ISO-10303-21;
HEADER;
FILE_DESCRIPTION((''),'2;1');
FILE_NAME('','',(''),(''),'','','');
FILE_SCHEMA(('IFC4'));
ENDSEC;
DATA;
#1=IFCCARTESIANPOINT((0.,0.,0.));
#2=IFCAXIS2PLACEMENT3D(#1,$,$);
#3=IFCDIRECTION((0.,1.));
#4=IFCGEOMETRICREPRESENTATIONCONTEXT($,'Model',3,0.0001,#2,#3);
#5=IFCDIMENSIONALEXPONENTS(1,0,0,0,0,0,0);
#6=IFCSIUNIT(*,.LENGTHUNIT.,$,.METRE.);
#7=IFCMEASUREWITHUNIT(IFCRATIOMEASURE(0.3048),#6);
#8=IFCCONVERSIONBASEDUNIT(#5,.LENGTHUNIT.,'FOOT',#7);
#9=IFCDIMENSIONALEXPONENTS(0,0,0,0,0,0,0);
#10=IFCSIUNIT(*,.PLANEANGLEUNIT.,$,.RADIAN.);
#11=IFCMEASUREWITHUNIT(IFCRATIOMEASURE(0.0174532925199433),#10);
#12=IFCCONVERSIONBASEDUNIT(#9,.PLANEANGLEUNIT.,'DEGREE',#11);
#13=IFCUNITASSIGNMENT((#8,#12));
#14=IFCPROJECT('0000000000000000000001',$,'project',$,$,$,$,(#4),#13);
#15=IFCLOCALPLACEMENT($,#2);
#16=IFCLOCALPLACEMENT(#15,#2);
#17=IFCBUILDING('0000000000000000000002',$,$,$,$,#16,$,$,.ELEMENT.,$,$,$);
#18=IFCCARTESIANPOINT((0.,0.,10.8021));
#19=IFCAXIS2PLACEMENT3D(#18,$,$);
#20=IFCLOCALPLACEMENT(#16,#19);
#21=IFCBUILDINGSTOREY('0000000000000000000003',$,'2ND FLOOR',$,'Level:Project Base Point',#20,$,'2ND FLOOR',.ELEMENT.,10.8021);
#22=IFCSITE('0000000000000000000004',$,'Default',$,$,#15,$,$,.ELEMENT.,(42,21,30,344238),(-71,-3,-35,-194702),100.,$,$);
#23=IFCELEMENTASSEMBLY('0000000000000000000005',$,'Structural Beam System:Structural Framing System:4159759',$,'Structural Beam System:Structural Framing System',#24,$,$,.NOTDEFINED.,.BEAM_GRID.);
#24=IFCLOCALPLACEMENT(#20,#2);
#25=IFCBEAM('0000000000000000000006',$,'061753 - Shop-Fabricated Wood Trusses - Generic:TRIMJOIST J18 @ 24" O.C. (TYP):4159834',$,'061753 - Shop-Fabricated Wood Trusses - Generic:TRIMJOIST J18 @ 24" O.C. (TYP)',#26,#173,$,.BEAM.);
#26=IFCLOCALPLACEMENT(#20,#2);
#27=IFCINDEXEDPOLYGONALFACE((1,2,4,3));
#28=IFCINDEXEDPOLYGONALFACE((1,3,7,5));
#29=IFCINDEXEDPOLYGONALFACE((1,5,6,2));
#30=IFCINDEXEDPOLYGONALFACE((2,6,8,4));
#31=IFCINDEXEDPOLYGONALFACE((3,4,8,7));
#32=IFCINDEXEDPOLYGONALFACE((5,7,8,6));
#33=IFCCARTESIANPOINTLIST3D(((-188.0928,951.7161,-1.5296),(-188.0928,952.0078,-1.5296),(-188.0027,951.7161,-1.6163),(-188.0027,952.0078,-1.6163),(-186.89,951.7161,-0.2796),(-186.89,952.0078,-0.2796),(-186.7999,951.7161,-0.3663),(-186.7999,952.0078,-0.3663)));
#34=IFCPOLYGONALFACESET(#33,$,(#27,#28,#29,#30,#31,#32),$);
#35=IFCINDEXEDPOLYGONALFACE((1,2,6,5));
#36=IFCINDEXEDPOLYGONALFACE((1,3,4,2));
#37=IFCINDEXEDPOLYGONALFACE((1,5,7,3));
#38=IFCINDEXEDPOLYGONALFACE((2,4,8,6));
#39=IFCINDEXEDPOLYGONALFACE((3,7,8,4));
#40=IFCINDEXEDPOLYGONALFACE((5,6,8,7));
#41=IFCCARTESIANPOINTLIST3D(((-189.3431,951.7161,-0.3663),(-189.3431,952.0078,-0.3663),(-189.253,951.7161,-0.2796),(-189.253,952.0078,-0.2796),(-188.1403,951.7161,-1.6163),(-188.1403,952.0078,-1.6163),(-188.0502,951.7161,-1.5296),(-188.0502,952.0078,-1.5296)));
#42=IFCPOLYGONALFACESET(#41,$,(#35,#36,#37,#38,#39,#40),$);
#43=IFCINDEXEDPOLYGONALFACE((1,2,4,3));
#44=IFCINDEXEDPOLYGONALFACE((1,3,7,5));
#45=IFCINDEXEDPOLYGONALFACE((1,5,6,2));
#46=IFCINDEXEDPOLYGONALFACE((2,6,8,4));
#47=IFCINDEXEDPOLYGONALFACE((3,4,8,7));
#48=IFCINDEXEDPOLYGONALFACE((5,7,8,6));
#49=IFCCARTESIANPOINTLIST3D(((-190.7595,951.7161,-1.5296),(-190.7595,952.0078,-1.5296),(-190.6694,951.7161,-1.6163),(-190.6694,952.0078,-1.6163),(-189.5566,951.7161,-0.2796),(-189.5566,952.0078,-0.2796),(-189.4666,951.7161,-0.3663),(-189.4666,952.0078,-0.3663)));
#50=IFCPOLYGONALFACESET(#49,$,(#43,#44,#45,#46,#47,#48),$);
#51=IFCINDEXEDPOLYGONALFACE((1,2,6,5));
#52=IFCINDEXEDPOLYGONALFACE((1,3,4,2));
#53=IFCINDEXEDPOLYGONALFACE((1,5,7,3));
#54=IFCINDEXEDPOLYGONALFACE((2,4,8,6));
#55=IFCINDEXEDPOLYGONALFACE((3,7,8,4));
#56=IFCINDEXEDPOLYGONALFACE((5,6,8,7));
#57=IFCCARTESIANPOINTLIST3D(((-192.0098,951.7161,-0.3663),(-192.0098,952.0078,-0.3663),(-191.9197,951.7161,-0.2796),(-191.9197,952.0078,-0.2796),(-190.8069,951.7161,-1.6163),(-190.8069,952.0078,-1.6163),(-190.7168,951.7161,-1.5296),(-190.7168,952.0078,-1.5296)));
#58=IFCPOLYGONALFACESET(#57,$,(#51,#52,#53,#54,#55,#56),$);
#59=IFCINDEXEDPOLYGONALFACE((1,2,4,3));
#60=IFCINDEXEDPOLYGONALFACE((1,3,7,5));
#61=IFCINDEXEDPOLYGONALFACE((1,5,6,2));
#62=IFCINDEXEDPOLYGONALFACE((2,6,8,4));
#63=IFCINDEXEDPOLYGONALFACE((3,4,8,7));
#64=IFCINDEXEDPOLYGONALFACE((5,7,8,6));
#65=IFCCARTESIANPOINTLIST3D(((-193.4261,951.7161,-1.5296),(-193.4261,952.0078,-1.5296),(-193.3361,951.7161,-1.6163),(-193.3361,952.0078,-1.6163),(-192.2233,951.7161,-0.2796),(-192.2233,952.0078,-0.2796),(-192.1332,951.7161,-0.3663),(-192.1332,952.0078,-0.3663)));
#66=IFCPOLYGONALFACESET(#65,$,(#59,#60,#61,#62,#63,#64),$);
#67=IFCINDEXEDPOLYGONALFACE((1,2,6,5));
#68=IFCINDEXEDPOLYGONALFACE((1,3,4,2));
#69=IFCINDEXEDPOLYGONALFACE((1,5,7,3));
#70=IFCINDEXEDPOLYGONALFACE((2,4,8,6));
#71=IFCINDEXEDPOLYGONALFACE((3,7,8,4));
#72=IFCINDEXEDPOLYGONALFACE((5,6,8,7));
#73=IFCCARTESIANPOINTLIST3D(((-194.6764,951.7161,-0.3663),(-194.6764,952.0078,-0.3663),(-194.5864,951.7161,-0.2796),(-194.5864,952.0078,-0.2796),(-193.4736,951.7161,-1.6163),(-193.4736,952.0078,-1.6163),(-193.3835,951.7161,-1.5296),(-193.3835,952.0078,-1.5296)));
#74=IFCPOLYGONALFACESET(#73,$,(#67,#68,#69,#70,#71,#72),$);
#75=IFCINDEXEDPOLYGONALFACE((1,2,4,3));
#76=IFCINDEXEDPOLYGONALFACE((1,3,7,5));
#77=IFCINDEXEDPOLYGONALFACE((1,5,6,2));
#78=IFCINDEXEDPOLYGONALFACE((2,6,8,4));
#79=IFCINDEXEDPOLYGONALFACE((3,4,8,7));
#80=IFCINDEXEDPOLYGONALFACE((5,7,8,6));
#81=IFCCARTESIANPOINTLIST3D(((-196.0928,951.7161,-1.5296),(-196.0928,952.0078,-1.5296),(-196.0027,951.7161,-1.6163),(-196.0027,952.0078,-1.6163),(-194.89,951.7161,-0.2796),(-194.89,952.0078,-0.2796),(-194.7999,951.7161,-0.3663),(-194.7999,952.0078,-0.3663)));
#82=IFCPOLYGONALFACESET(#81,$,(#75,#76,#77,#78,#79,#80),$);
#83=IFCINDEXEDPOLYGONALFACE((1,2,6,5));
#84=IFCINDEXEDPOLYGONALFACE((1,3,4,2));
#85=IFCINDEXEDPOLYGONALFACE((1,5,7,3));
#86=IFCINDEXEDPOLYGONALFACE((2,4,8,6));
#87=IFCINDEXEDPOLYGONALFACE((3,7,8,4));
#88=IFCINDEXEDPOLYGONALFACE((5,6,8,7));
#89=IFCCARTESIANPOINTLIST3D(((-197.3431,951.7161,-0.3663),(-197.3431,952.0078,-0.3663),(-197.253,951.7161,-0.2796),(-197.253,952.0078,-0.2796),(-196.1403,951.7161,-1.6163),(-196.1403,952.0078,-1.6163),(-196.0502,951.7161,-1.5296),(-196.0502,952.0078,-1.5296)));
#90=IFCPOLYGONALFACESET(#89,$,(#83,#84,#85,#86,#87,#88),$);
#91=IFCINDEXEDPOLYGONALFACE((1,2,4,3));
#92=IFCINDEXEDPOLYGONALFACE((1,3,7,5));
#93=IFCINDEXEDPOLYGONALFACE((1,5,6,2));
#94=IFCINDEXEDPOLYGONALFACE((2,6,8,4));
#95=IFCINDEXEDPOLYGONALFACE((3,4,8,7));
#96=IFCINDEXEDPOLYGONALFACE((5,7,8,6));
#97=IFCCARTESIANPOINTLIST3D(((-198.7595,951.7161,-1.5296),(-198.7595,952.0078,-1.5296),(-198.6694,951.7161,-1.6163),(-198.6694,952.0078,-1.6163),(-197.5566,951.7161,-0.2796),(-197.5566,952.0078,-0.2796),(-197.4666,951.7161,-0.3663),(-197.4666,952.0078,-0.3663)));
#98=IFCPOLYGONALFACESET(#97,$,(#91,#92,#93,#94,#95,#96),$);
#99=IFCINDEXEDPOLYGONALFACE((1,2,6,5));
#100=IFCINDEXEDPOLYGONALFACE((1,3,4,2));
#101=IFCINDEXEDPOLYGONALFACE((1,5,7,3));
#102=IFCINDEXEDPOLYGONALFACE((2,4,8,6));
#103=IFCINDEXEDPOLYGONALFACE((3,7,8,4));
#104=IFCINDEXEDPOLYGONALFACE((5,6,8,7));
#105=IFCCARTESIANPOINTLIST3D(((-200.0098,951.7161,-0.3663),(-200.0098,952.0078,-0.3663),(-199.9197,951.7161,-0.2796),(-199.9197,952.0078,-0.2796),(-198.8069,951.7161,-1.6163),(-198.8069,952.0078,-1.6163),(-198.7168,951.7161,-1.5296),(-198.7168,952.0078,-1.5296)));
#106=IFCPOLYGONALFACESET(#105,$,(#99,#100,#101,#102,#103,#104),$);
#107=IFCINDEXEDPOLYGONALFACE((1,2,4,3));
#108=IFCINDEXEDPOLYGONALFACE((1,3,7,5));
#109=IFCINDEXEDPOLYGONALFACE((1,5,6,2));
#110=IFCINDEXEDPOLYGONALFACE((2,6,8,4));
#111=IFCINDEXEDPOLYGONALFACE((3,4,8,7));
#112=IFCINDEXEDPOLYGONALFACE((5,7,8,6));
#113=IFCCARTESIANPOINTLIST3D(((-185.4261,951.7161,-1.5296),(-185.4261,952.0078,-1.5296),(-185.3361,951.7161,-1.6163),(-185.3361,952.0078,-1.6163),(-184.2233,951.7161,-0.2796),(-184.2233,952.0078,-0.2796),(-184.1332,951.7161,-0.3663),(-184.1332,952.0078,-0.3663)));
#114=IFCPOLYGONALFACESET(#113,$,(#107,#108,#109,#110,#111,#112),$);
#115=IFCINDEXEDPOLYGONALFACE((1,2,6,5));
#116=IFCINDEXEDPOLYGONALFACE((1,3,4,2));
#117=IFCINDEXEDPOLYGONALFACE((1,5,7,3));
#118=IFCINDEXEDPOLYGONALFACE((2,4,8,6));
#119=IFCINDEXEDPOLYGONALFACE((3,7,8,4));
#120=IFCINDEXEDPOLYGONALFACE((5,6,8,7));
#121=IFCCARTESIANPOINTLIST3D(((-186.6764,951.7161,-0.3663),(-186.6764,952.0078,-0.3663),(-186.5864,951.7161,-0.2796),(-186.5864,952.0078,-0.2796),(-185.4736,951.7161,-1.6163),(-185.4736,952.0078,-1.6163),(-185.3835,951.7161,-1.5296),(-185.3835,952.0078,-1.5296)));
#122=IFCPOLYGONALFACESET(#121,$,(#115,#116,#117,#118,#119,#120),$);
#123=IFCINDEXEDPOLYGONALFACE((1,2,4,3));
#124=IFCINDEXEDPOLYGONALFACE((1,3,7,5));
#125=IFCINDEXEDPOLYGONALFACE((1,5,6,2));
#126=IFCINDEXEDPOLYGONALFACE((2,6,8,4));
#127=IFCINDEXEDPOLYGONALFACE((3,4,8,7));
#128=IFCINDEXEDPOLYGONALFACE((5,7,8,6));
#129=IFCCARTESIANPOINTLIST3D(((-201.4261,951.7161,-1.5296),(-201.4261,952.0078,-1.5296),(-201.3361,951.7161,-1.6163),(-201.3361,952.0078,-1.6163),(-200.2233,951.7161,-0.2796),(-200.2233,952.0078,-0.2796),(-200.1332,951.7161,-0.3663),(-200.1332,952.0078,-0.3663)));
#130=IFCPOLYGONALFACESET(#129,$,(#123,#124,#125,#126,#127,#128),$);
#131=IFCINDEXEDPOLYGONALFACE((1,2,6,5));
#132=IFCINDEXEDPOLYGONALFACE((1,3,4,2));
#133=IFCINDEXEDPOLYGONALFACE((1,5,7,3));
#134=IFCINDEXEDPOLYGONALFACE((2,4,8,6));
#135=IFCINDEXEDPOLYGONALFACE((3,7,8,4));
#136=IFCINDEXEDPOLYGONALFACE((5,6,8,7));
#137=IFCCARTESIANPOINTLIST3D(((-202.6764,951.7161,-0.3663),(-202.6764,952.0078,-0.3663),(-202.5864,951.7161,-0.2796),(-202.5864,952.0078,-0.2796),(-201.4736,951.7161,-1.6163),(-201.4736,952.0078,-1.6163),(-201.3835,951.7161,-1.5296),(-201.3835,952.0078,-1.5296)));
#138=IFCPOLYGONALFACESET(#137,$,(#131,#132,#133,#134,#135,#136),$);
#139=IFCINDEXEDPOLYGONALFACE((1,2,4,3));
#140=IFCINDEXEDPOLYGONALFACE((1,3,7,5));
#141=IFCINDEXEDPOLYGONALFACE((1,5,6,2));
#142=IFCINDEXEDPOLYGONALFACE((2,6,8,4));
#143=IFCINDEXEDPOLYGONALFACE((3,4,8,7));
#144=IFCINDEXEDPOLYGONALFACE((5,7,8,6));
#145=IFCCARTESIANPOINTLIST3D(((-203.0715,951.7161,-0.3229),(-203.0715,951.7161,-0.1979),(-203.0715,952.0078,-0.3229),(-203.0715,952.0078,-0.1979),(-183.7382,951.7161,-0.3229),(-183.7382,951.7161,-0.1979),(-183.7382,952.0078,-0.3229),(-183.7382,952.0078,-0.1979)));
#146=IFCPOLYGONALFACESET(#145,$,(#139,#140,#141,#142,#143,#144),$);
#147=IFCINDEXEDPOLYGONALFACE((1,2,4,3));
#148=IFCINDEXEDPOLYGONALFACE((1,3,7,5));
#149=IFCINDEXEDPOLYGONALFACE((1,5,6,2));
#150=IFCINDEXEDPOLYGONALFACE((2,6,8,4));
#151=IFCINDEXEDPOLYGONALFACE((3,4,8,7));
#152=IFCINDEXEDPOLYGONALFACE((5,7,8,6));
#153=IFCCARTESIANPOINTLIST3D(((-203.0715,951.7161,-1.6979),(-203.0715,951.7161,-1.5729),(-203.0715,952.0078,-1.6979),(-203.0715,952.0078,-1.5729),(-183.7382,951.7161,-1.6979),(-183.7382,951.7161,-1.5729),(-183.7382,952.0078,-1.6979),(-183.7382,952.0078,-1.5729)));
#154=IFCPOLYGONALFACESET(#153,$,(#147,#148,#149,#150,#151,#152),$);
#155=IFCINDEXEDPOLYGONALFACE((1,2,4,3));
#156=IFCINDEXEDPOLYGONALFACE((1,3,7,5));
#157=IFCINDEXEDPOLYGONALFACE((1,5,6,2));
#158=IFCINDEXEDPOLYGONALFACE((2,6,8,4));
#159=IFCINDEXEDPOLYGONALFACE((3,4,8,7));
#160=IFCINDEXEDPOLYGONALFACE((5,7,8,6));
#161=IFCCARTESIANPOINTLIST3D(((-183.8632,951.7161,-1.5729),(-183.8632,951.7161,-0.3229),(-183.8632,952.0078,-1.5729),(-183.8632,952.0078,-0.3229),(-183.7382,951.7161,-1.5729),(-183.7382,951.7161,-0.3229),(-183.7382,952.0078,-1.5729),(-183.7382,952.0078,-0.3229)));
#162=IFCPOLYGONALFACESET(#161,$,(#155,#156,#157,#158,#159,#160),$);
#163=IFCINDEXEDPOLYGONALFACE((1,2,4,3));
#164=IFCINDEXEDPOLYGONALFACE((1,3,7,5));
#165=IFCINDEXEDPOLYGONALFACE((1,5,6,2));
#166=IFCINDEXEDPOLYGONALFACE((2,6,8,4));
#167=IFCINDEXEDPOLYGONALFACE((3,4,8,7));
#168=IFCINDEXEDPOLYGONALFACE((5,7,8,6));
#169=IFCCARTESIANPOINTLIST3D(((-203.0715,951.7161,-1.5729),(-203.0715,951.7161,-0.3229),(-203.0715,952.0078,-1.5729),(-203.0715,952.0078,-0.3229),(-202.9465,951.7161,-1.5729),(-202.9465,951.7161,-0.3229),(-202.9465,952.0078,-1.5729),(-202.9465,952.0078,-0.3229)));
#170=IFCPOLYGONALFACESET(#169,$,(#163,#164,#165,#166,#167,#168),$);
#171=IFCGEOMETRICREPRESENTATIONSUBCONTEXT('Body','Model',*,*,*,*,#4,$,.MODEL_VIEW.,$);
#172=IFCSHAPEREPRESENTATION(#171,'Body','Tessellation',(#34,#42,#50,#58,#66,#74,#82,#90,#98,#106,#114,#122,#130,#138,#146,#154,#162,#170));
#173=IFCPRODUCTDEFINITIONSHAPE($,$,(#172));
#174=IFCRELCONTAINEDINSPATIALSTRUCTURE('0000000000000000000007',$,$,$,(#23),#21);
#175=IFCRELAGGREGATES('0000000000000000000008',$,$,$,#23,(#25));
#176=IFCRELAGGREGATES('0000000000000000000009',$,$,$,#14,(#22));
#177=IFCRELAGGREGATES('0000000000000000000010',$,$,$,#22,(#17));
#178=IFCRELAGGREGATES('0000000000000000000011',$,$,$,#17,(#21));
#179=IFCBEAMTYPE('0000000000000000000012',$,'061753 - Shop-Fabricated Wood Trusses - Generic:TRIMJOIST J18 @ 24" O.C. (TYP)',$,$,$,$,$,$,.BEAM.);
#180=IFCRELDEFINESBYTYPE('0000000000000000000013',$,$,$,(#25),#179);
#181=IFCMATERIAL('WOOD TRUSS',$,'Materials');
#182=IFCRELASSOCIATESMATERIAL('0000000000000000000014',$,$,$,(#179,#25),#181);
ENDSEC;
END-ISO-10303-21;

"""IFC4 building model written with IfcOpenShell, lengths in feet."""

from ifc_helpers import new_model, entity, si_unit, converted_unit, direction, frame, frame_2d, origin, origin_2d_with_axis, place, context, subcontext, project, spatial, rectangle, extrude, source, transform, mapped, material, material_profile, profile_set, profile_usage, type_object, type_shapes, element, aggregate, save


model = new_model("IFC4")

# Units and contexts
model_context = context("Model", 3, precision=0.0001, world=origin(), true_north=direction((0.0, 1.0)))
body_context = subcontext(model_context, "Body", "Model", "MODEL_VIEW")
ifc_project = project(units=[converted_unit("LENGTHUNIT", "FOOT", entity("IfcRatioMeasure", 0.3048), si_unit("LENGTHUNIT", "METRE"), dimensions=[1, 0, 0, 0, 0, 0, 0]), converted_unit("PLANEANGLEUNIT", "DEGREE", entity("IfcRatioMeasure", 0.0174532925199433), si_unit("PLANEANGLEUNIT", "RADIAN"), dimensions=[0, 0, 0, 0, 0, 0, 0])], contexts=[model_context])

# Site, building, storey
site_placement = place(None, origin())
site = spatial("IfcSite", under=ifc_project, at=site_placement, Name="Default", CompositionType="ELEMENT", RefLatitude=(42, 21, 30, 344238), RefLongitude=(-71, -3, -35, -194702), RefElevation=100.0)
building_placement = place(site_placement, origin())
building = spatial("IfcBuilding", under=site, at=building_placement, CompositionType="ELEMENT")
storey_placement = place(building_placement, frame((0.0, 0.0, 10.8021)))
storey = spatial("IfcBuildingStorey", under=building, at=storey_placement, Name="2ND FLOOR", ObjectType="Level:Project Base Point", LongName="2ND FLOOR", CompositionType="ELEMENT", Elevation=10.8021)

# Element assembly, beam
ifc_material_1 = material(Name="WOOD TRUSS", Category="Materials")
ifc_material_profile_1 = material_profile(ifc_material_1, rectangle(XDim=1.7347, YDim=0.125, at=frame_2d((0.0, 0.0), x_axis=(1.0, 0.0))), Name="TRIMJOIST J18 @ 24\" O.C. (TYP)")
ifc_material_profile_2 = material_profile(ifc_material_1, rectangle(XDim=1.7347, YDim=0.125, at=frame_2d((0.0, 0.0), x_axis=(1.0, 0.0))), Name="TRIMJOIST J18 @ 24\" O.C. (TYP)")
ifc_material_profile_3 = material_profile(ifc_material_1, rectangle(XDim=1.7347, YDim=0.125, at=frame_2d((0.0, 0.0), x_axis=(1.0, 0.0))), Name="TRIMJOIST J18 @ 24\" O.C. (TYP)")
ifc_material_profile_4 = material_profile(ifc_material_1, rectangle(XDim=1.7347, YDim=0.125, at=frame_2d((0.0, 0.0), x_axis=(1.0, 0.0))), Name="TRIMJOIST J18 @ 24\" O.C. (TYP)")
ifc_material_profile_5 = material_profile(ifc_material_1, rectangle(XDim=1.7347, YDim=0.125, at=frame_2d((0.0, 0.0), x_axis=(1.0, 0.0))), Name="TRIMJOIST J18 @ 24\" O.C. (TYP)")
ifc_material_profile_6 = material_profile(ifc_material_1, rectangle(XDim=1.7347, YDim=0.125, at=frame_2d((0.0, 0.0), x_axis=(1.0, 0.0))), Name="TRIMJOIST J18 @ 24\" O.C. (TYP)")
ifc_material_profile_7 = material_profile(ifc_material_1, rectangle(XDim=1.7347, YDim=0.125, at=frame_2d((0.0, 0.0), x_axis=(1.0, 0.0))), Name="TRIMJOIST J18 @ 24\" O.C. (TYP)")
ifc_material_profile_8 = material_profile(ifc_material_1, rectangle(XDim=1.7347, YDim=0.125, at=frame_2d((0.0, 0.0), x_axis=(1.0, 0.0))), Name="TRIMJOIST J18 @ 24\" O.C. (TYP)")
ifc_material_profile_9 = material_profile(ifc_material_1, rectangle(XDim=1.7347, YDim=0.125, at=frame_2d((0.0, 0.0), x_axis=(1.0, 0.0))), Name="TRIMJOIST J18 @ 24\" O.C. (TYP)")
ifc_material_profile_10 = material_profile(ifc_material_1, rectangle(XDim=1.7347, YDim=0.125, at=origin_2d_with_axis()), Name="TRIMJOIST J18 @ 24\" O.C. (TYP)")
ifc_material_profile_11 = material_profile(ifc_material_1, rectangle(XDim=0.125, YDim=0.2917, at=origin_2d_with_axis()), Name="TRIMJOIST J18 @ 24\" O.C. (TYP)")
ifc_material_profile_12 = material_profile(ifc_material_1, rectangle(XDim=0.125, YDim=0.2917, at=origin_2d_with_axis()), Name="TRIMJOIST J18 @ 24\" O.C. (TYP)")
ifc_material_profile_13 = material_profile(ifc_material_1, rectangle(XDim=1.25, YDim=0.2917, at=origin_2d_with_axis()), Name="TRIMJOIST J18 @ 24\" O.C. (TYP)")
ifc_material_profile_14 = material_profile(ifc_material_1, rectangle(XDim=1.25, YDim=0.2917, at=origin_2d_with_axis()), Name="TRIMJOIST J18 @ 24\" O.C. (TYP)")
ifc_profile_set_1 = profile_set([ifc_material_profile_1, ifc_material_profile_2, ifc_material_profile_3, ifc_material_profile_4, ifc_material_profile_5, ifc_material_profile_6, ifc_material_profile_7, ifc_material_profile_8, ifc_material_profile_9, ifc_material_profile_10, ifc_material_profile_11, ifc_material_profile_12, ifc_material_profile_13, ifc_material_profile_14], Name="TRIMJOIST J18 @ 24\" O.C. (TYP)")
beam_type_1 = type_object("IfcBeamType", Name="061753 - Shop-Fabricated Wood Trusses - Generic:TRIMJOIST J18 @ 24\" O.C. (TYP)", PredefinedType="BEAM", material=ifc_profile_set_1)
shared_shape_1 = source(origin(), body_context, "Body", "SweptSolid", [
    extrude(rectangle(XDim=1.7347, YDim=0.125, at=frame_2d((0.0, 0.0), x_axis=(1.0, 0.0))), frame((5.9585, -0.1458, 0.0), z_axis=(0.0, 1.0, 0.0), x_axis=(0.693383, 0.0, 0.720569)), (0.0, 0.0, 1.0), 0.2917),
    extrude(rectangle(XDim=1.7347, YDim=0.125, at=origin_2d_with_axis()), frame((4.7082, -0.1458, 0.0), z_axis=(0.0, 1.0, 0.0), x_axis=(0.693383, 0.0, -0.720569)), (0.0, 0.0, 1.0), 0.2917),
    extrude(rectangle(XDim=1.7347, YDim=0.125, at=frame_2d((0.0, 0.0), x_axis=(1.0, 0.0))), frame((3.2918, -0.1458, 0.0), z_axis=(0.0, 1.0, 0.0), x_axis=(0.693383, 0.0, 0.720569)), (0.0, 0.0, 1.0), 0.2917),
    extrude(rectangle(XDim=1.7347, YDim=0.125, at=frame_2d((0.0, 0.0), x_axis=(1.0, 0.0))), frame((2.0415, -0.1458, 0.0), z_axis=(0.0, 1.0, 0.0), x_axis=(0.693383, 0.0, -0.720569)), (0.0, 0.0, 1.0), 0.2917),
    extrude(rectangle(XDim=1.7347, YDim=0.125, at=frame_2d((0.0, 0.0), x_axis=(1.0, 0.0))), frame((0.6251, -0.1458, 0.0), z_axis=(0.0, 1.0, 0.0), x_axis=(0.693383, 0.0, 0.720569)), (0.0, 0.0, 1.0), 0.2917),
    extrude(rectangle(XDim=1.7347, YDim=0.125, at=frame_2d((0.0, 0.0), x_axis=(1.0, 0.0))), frame((-0.6251, -0.1458, 0.0), z_axis=(0.0, 1.0, 0.0), x_axis=(0.693383, 0.0, -0.720569)), (0.0, 0.0, 1.0), 0.2917),
    extrude(rectangle(XDim=1.7347, YDim=0.125, at=frame_2d((0.0, 0.0), x_axis=(1.0, 0.0))), frame((-2.0415, -0.1458, 0.0), z_axis=(0.0, 1.0, 0.0), x_axis=(0.693383, 0.0, 0.720569)), (0.0, 0.0, 1.0), 0.2917),
    extrude(rectangle(XDim=1.7347, YDim=0.125, at=origin_2d_with_axis()), frame((-3.2918, -0.1458, 0.0), z_axis=(0.0, 1.0, 0.0), x_axis=(0.693383, 0.0, -0.720569)), (0.0, 0.0, 1.0), 0.2917),
    extrude(rectangle(XDim=1.7347, YDim=0.125, at=frame_2d((0.0, 0.0), x_axis=(1.0, 0.0))), frame((-4.7082, -0.1458, 0.0), z_axis=(0.0, 1.0, 0.0), x_axis=(0.693383, 0.0, 0.720569)), (0.0, 0.0, 1.0), 0.2917),
    extrude(rectangle(XDim=1.7347, YDim=0.125, at=frame_2d((0.0, 0.0), x_axis=(1.0, 0.0))), frame((-5.9585, -0.1458, 0.0), z_axis=(0.0, 1.0, 0.0), x_axis=(0.693383, 0.0, -0.720569)), (0.0, 0.0, 1.0), 0.2917),
    extrude(rectangle(XDim=1.7347, YDim=0.125, at=frame_2d((0.0, 0.0), x_axis=(1.0, 0.0))), frame((8.6251, -0.1458, 0.0), z_axis=(0.0, 1.0, 0.0), x_axis=(0.693383, 0.0, 0.720569)), (0.0, 0.0, 1.0), 0.2917),
    extrude(rectangle(XDim=1.7347, YDim=0.125, at=origin_2d_with_axis()), frame((7.3749, -0.1458, 0.0), z_axis=(0.0, 1.0, 0.0), x_axis=(0.693383, 0.0, -0.720569)), (0.0, 0.0, 1.0), 0.2917),
    extrude(rectangle(XDim=1.7347, YDim=0.125, at=frame_2d((0.0, 0.0), x_axis=(1.0, 0.0))), frame((-7.3749, -0.1458, 0.0), z_axis=(0.0, 1.0, 0.0), x_axis=(0.693383, 0.0, 0.720569)), (0.0, 0.0, 1.0), 0.2917),
    extrude(rectangle(XDim=1.7347, YDim=0.125, at=origin_2d_with_axis()), frame((-8.6251, -0.1458, 0.0), z_axis=(0.0, 1.0, 0.0), x_axis=(0.693383, 0.0, -0.720569)), (0.0, 0.0, 1.0), 0.2917),
    extrude(rectangle(XDim=0.125, YDim=0.2917, at=origin_2d_with_axis()), frame((-9.6667, 0.0, 0.6875), z_axis=(1.0, 0.0, 0.0), x_axis=(0.0, 0.0, -1.0)), (0.0, 0.0, 1.0), 19.3333),
    extrude(rectangle(XDim=0.125, YDim=0.2917, at=origin_2d_with_axis()), frame((-9.6667, 0.0, -0.6875), z_axis=(1.0, 0.0, 0.0), x_axis=(0.0, 0.0, -1.0)), (0.0, 0.0, 1.0), 19.3333),
    extrude(rectangle(XDim=1.25, YDim=0.2917, at=origin_2d_with_axis()), frame((9.5417, 0.0, 0.0), z_axis=(1.0, 0.0, 0.0), x_axis=(0.0, 0.0, -1.0)), (0.0, 0.0, 1.0), 0.125),
    extrude(rectangle(XDim=1.25, YDim=0.2917, at=origin_2d_with_axis()), frame((-9.6667, 0.0, 0.0), z_axis=(1.0, 0.0, 0.0), x_axis=(0.0, 0.0, -1.0)), (0.0, 0.0, 1.0), 0.125),
])
type_shapes(beam_type_1, [shared_shape_1])
assembly_1_placement = place(storey_placement, origin())
assembly_1 = element("IfcElementAssembly", 1, at=assembly_1_placement, inside=storey, Name="Structural Beam System:Structural Framing System:4159759", ObjectType="Structural Beam System:Structural Framing System", AssemblyPlace="NOTDEFINED", PredefinedType="BEAM_GRID")
ifc_profile_usage_1 = profile_usage(ifc_profile_set_1, cardinal=8)
beam_1_placement = place(assembly_1_placement, frame((-193.4048, 951.8619, -0.9479)))
beam_1 = element("IfcBeam", 2, at=beam_1_placement, type_object=beam_type_1, material=ifc_profile_usage_1, Name="061753 - Shop-Fabricated Wood Trusses - Generic:TRIMJOIST J18 @ 24\" O.C. (TYP):4159834", ObjectType="061753 - Shop-Fabricated Wood Trusses - Generic:TRIMJOIST J18 @ 24\" O.C. (TYP)", PredefinedType="BEAM", context=body_context, shape_type="MappedRepresentation", body=[
    mapped(shared_shape_1, transform((0.0, 0.0, 0.0), scale=1.0)),
])

aggregate(assembly_1, [beam_1])

save(model, "model.ifc")
